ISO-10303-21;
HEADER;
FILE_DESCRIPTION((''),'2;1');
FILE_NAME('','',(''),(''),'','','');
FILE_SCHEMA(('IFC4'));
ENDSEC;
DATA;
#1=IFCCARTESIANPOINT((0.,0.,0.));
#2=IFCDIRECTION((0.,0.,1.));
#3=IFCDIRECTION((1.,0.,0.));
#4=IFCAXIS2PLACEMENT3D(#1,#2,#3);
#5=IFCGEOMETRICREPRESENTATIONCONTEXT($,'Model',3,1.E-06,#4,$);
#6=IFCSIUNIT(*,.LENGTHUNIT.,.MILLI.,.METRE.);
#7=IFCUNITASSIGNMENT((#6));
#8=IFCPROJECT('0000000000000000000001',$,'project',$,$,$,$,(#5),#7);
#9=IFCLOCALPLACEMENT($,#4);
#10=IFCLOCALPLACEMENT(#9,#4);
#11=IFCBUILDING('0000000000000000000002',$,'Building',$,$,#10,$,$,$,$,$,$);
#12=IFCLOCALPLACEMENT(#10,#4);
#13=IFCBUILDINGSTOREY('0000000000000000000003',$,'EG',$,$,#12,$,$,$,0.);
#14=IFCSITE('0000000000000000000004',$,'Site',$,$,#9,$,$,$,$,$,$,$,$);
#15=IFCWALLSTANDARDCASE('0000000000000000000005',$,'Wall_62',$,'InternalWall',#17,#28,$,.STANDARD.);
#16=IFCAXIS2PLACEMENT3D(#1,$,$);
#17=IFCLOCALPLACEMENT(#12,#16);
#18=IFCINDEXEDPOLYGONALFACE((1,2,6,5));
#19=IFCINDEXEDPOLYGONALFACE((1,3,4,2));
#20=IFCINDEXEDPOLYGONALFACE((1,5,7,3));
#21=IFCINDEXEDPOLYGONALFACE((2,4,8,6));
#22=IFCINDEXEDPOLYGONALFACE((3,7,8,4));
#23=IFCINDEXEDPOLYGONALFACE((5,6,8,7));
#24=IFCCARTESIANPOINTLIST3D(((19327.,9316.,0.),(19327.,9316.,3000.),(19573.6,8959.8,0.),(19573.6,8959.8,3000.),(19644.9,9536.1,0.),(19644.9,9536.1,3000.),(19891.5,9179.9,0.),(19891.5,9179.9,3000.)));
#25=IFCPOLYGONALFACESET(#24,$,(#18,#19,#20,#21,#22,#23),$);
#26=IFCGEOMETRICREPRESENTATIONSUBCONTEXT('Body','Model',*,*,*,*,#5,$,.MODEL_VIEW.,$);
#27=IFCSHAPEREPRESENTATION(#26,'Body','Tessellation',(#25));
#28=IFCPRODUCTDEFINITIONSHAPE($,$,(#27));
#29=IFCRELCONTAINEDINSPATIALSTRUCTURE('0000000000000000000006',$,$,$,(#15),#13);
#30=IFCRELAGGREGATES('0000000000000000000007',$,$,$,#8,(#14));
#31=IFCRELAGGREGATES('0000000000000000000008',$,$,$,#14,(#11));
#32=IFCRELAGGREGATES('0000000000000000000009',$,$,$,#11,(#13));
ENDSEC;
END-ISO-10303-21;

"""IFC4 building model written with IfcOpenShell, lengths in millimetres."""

from ifc_helpers import new_model, si_unit, frame, origin_with_axes, place, context, subcontext, project, spatial, rectangle, extrude, element, save


model = new_model("IFC4")

# Units and contexts
model_context = context("Model", 3, precision=1e-06, world=origin_with_axes())
body_context = subcontext(model_context, "Body", "Model", "MODEL_VIEW")
ifc_project = project(units=[si_unit("LENGTHUNIT", "METRE", prefix="MILLI")], contexts=[model_context])

# Site, building, storey
site_placement = place(None, origin_with_axes())
site = spatial("IfcSite", under=ifc_project, at=site_placement, Name="Site")
building_placement = place(site_placement, origin_with_axes())
building = spatial("IfcBuilding", under=site, at=building_placement, Name="Building")
storey_placement = place(building_placement, origin_with_axes())
storey = spatial("IfcBuildingStorey", under=building, at=storey_placement, Name="EG", Elevation=0.0)

# Wall
wall_1_placement = place(storey_placement, origin_with_axes())
element("IfcWallStandardCase", 1, at=wall_1_placement, inside=storey, Name="Wall_62", ObjectType="InternalWall", PredefinedType="STANDARD", context=body_context, shape_type="SweptSolid", body=[
    extrude(rectangle(XDim=433.2, YDim=386.7), frame((19609.2, 9247.9, 0.0), z_axis=(0.0, 0.0, 1.0), x_axis=(-0.56921, 0.822192, 0.0)), (0.0, 0.0, 1.0), 3000.0),
])

save(model, "model.ifc")
